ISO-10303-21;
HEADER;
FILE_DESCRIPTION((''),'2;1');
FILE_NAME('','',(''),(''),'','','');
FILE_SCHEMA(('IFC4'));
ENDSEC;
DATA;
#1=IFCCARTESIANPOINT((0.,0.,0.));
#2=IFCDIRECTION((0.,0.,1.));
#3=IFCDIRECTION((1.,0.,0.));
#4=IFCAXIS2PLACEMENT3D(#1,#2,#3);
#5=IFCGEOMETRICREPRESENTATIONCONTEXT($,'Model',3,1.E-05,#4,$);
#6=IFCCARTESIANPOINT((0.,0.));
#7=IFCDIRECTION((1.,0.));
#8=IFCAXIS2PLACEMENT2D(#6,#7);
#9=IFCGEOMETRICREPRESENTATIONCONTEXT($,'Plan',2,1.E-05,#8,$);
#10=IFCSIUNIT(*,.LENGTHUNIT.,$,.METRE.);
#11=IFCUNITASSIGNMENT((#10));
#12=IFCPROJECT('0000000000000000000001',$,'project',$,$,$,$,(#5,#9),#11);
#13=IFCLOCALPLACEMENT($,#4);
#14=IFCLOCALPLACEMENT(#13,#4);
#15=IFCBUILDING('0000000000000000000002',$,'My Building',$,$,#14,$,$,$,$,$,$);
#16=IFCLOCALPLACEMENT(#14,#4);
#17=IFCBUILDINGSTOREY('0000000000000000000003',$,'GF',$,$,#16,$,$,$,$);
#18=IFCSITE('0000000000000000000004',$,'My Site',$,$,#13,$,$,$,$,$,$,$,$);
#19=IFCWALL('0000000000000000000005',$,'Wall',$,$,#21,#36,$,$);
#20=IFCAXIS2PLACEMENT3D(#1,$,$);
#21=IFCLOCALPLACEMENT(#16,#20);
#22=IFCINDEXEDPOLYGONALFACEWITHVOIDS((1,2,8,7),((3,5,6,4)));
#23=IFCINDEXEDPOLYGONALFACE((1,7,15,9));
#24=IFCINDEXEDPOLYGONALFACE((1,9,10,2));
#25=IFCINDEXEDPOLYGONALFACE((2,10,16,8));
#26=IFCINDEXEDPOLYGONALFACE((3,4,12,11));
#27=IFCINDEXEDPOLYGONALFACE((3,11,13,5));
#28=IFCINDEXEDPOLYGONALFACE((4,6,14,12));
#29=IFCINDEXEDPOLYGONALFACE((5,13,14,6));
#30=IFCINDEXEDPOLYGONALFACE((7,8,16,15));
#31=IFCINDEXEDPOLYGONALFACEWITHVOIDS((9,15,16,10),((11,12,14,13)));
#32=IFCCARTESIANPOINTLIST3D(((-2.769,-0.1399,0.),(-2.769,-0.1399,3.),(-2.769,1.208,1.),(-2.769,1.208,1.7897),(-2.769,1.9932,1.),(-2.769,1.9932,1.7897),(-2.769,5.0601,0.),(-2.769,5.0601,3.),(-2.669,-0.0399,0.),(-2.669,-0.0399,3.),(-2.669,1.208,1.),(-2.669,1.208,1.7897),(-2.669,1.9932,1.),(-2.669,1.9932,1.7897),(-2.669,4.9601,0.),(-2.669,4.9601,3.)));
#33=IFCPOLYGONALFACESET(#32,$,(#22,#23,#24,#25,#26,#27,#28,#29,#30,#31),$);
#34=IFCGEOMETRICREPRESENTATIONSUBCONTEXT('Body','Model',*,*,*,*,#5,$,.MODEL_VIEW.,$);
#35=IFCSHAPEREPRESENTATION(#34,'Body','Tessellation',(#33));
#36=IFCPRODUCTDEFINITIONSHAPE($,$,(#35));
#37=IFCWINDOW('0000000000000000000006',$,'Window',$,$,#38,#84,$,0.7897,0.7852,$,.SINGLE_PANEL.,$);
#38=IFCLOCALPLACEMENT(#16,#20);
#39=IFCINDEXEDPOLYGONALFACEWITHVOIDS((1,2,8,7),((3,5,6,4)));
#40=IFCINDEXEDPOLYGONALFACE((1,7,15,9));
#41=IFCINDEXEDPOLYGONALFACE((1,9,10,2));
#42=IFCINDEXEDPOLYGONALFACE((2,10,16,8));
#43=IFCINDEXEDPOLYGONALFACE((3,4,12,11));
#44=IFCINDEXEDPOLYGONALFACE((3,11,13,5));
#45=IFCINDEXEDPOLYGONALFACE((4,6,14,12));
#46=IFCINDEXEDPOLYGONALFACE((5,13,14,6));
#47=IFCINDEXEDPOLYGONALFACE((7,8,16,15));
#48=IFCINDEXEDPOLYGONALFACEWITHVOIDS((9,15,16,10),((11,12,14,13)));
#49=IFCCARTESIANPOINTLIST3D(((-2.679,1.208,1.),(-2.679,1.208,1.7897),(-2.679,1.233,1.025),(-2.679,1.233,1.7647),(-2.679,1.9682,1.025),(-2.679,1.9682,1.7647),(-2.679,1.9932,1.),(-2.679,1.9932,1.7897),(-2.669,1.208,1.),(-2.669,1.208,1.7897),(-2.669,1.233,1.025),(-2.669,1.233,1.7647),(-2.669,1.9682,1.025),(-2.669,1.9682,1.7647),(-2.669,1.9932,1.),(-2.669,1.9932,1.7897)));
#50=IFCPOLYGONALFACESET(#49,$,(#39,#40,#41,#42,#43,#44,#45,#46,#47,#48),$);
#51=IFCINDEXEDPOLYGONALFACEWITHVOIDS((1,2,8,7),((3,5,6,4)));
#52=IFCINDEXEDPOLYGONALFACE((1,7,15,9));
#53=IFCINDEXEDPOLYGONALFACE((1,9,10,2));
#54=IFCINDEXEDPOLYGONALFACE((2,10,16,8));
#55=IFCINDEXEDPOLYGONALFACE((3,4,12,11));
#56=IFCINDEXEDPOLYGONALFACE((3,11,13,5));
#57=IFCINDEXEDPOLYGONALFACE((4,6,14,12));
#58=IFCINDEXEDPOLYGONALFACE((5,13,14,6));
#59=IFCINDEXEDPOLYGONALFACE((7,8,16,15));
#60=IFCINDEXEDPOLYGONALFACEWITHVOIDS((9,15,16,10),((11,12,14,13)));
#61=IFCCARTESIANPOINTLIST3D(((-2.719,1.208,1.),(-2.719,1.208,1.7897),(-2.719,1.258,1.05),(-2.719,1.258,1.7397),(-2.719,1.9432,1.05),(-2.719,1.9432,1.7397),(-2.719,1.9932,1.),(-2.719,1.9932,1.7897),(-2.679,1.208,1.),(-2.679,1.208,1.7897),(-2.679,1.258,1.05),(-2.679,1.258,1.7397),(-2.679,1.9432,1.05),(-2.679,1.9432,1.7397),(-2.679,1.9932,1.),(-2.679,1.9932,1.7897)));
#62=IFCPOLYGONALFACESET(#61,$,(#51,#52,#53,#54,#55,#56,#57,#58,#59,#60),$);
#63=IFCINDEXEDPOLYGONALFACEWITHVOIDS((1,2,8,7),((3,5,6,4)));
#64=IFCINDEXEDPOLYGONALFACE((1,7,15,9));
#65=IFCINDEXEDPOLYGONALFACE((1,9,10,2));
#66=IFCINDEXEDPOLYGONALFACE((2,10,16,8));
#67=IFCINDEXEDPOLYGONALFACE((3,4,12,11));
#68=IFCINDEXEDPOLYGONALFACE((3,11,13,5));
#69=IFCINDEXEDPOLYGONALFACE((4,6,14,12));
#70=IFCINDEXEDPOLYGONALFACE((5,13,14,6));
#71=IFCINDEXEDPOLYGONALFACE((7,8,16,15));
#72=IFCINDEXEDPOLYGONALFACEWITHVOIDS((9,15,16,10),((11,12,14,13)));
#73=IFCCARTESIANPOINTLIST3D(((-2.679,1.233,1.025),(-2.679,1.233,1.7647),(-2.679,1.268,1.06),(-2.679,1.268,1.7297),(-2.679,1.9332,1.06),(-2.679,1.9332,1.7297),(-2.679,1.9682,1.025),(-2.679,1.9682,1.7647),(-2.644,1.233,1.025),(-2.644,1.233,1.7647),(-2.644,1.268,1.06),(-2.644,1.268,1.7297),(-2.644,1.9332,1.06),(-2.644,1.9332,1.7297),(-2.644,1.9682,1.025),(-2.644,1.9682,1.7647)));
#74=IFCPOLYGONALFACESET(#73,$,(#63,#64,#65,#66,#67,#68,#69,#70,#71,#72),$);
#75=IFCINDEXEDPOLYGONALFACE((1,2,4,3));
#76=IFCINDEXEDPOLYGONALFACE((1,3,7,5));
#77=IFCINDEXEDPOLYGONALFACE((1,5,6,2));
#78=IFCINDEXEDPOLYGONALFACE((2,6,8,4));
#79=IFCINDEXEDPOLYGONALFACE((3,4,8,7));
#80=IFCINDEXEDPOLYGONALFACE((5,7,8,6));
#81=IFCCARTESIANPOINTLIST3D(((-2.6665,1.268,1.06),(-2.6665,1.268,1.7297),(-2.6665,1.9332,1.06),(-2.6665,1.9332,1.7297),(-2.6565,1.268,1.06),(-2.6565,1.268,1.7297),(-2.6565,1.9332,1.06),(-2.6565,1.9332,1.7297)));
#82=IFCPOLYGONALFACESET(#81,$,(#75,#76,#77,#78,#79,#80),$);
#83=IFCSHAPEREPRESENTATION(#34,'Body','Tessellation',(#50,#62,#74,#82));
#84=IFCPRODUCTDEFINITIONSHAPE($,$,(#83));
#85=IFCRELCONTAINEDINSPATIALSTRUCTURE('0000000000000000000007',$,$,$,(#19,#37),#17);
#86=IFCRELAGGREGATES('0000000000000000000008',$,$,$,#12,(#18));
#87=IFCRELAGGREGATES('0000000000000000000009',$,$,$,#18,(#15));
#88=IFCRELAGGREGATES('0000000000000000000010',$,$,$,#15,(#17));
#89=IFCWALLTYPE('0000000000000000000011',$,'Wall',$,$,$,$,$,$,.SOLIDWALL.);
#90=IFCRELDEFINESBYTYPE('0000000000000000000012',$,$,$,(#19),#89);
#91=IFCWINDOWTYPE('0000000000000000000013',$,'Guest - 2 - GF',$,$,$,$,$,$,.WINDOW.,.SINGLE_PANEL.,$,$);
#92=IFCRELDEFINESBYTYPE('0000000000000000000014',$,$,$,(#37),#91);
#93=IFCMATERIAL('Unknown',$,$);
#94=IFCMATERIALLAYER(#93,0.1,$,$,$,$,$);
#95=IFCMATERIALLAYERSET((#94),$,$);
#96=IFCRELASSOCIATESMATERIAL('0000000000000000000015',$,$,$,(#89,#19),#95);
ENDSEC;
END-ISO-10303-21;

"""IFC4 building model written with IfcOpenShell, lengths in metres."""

from ifc_helpers import new_model, entity, si_unit, frame, origin_with_axes, origin_2d_with_axis, place, context, subcontext, project, spatial, line, indexed_curve, outline, extrude, shape, source, transform, mapped, material, layer, layer_set, layer_usage, type_object, type_shapes, element, fill, save


model = new_model("IFC4")

# Units and contexts
model_context = context("Model", 3, precision=1e-05, world=origin_with_axes())
plan_context = context("Plan", 2, precision=1e-05, world=origin_2d_with_axis())
body_context_1 = subcontext(model_context, "Body", "Model", "MODEL_VIEW")
body_context_2 = subcontext(plan_context, "Body", "Plan", "PLAN_VIEW")
ifc_project = project(units=[si_unit("LENGTHUNIT", "METRE")], contexts=[model_context, plan_context])

# Site, building, storey
site_placement = place(None, origin_with_axes())
site = spatial("IfcSite", under=ifc_project, at=site_placement, Name="My Site")
building_placement = place(site_placement, origin_with_axes())
building = spatial("IfcBuilding", under=site, at=building_placement, Name="My Building")
storey_placement = place(building_placement, origin_with_axes())
storey = spatial("IfcBuildingStorey", under=building, at=storey_placement, Name="GF")

# Shared definitions
ifc_material = material(Name="Unknown")

# Shared definitions
ifc_layer_1 = layer(ifc_material, 0.1)
ifc_layer_set_1 = layer_set([ifc_layer_1])
wall_type = type_object("IfcWallType", Name="Wall", PredefinedType="SOLIDWALL", material=ifc_layer_set_1)

# Wall, opening, window
ifc_layer_usage_1 = layer_usage(ifc_layer_set_1, "AXIS2", "POSITIVE", 0.0)
wall_1_placement = place(storey_placement, frame((-2.769, 5.0601, 0.0), z_axis=(0.0, 0.0, 1.0), x_axis=(0.0, -1.0, 0.0)))
wall_1 = element("IfcWall", 1, at=wall_1_placement, inside=storey, type_object=wall_type, material=ifc_layer_usage_1, Name="Wall", context=body_context_1, shape_type="SweptSolid", body=[
    extrude(outline(indexed_curve([(0.0, 0.0), (0.1, 0.1), (5.1, 0.1), (5.2, 0.0)], segments=[line(1, 2, 3, 4, 1)])), origin_with_axes(), (0.0, 0.0, 1.0), 3.0),
])
shared_shape_1 = source(origin_with_axes(), body_context_1, "Body", "SweptSolid", [
    extrude(outline(indexed_curve([(0.0, 0.0), (0.7852, 0.0), (0.7852, 0.7897), (0.0, 0.7897)], segments=[line(1, 2, 3, 4, 1)])), frame((0.0, -0.6, 0.0), z_axis=(0.0, -1.0, 0.0), x_axis=(1.0, 0.0, 0.0)), (0.0, 0.0, -1.0), 1.2),
])
opening_1_placement = place(wall_1_placement, frame((3.0669, 0.0, 1.0), z_axis=(0.0, 0.0, 1.0), x_axis=(1.0, 0.0, 0.0)))
opening_1 = element("IfcOpeningElement", 2, at=opening_1_placement, cuts=wall_1, PredefinedType="OPENING", context=body_context_1, shape_type="MappedRepresentation", body=[
    mapped(shared_shape_1, transform((0.0, 0.0, 0.0), x_axis=(1.0, 0.0, 0.0), y_axis=(0.0, 1.0, 0.0), z_axis=(0.0, 0.0, 1.0), scale=1.0)),
])
window_type_1 = type_object("IfcWindowType", Name="Guest - 2 - GF", PartitioningType="SINGLE_PANEL", PredefinedType="WINDOW")
shared_shape_2 = source(origin_with_axes(), body_context_1, "Body", "SweptSolid", [
    extrude(outline(indexed_curve([(0.0, 0.0), (0.7852, 0.0), (0.7852, 0.7897), (0.0, 0.7897)], segments=[line(1, 2, 3, 4, 1)]), holes=[indexed_curve([(0.025, 0.025), (0.7602, 0.025), (0.7602, 0.7647), (0.025, 0.7647)], segments=[line(1, 2, 3, 4, 1)])]), frame((0.0, 0.09, 0.0), z_axis=(0.0, -1.0, 0.0), x_axis=(1.0, 0.0, 0.0)), (0.0, 0.0, -1.0), 0.01),
    extrude(outline(indexed_curve([(0.0, 0.0), (0.7852, 0.0), (0.7852, 0.7897), (0.0, 0.7897)], segments=[line(1, 2, 3, 4, 1)]), holes=[indexed_curve([(0.05, 0.05), (0.7352, 0.05), (0.7352, 0.7397), (0.05, 0.7397)], segments=[line(1, 2, 3, 4, 1)])]), frame((0.0, 0.05, 0.0), z_axis=(0.0, -1.0, 0.0), x_axis=(1.0, 0.0, 0.0)), (0.0, 0.0, -1.0), 0.04),
    extrude(outline(indexed_curve([(0.0, 0.0), (0.7352, 0.0), (0.7352, 0.7397), (0.0, 0.7397)], segments=[line(1, 2, 3, 4, 1)]), holes=[indexed_curve([(0.035, 0.035), (0.7002, 0.035), (0.7002, 0.7047), (0.035, 0.7047)], segments=[line(1, 2, 3, 4, 1)])]), frame((0.025, 0.09, 0.025), z_axis=(0.0, -1.0, 0.0), x_axis=(1.0, 0.0, 0.0)), (0.0, 0.0, -1.0), 0.035),
    extrude(outline(indexed_curve([(0.035, 0.035), (0.7002, 0.035), (0.7002, 0.7047), (0.035, 0.7047)], segments=[line(1, 2, 3, 4, 1)])), frame((0.025, 0.1025, 0.025), z_axis=(0.0, -1.0, 0.0), x_axis=(1.0, 0.0, 0.0)), (0.0, 0.0, -1.0), 0.01),
])
shared_shape_3 = source(origin_with_axes(), body_context_2, "Body", "Curve2D", [
    entity("IfcIndexedPolyCurve", entity("IfcCartesianPointList2D", [[0.05, 0.05], [0.7352, 0.05]])),
    entity("IfcIndexedPolyCurve", entity("IfcCartesianPointList2D", [[0.0, 0.1], [0.025, 0.1], [0.025, 0.09], [0.05, 0.09], [0.05, 0.05], [0.0, 0.05]]), [entity("IfcLineIndex", [1, 2, 3, 4, 5, 6, 1])]),
    entity("IfcIndexedPolyCurve", entity("IfcCartesianPointList2D", [[0.7852, 0.1], [0.7602, 0.1], [0.7602, 0.09], [0.7352, 0.09], [0.7352, 0.05], [0.7852, 0.05]]), [entity("IfcLineIndex", [1, 2, 3, 4, 5, 6, 1])]),
    entity("IfcIndexedPolyCurve", entity("IfcCartesianPointList2D", [[0.025, 0.09], [0.06, 0.09], [0.06, 0.125], [0.025, 0.125]]), [entity("IfcLineIndex", [1, 2, 3, 4, 1])]),
    entity("IfcIndexedPolyCurve", entity("IfcCartesianPointList2D", [[0.7602, 0.09], [0.7252, 0.09], [0.7252, 0.125], [0.7602, 0.125]]), [entity("IfcLineIndex", [1, 2, 3, 4, 1])]),
    entity("IfcIndexedPolyCurve", entity("IfcCartesianPointList2D", [[0.06, 0.09], [0.7252, 0.09]])),
    entity("IfcIndexedPolyCurve", entity("IfcCartesianPointList2D", [[0.06, 0.125], [0.7252, 0.125]])),
    entity("IfcIndexedPolyCurve", entity("IfcCartesianPointList2D", [[0.06, 0.1075], [0.7252, 0.1075]])),
])
type_shapes(window_type_1, [shared_shape_2, shared_shape_3])
window_1_placement = place(opening_1_placement, frame((0.0, 0.0, 0.0), z_axis=(0.0, 0.0, 1.0), x_axis=(1.0, 0.0, 0.0)))
window_1 = element("IfcWindow", 3, at=window_1_placement, inside=storey, type_object=window_type_1, Name="Window", OverallHeight=0.7897, OverallWidth=0.7852, PartitioningType="SINGLE_PANEL", shapes=[
    shape(body_context_1, "Body", "MappedRepresentation", [mapped(shared_shape_2, transform((0.0, 0.0, 0.0), x_axis=(1.0, 0.0, 0.0), y_axis=(0.0, 1.0, 0.0), z_axis=(0.0, 0.0, 1.0), scale=1.0))]),
    shape(body_context_2, "Body", "MappedRepresentation", [mapped(shared_shape_3, transform((0.0, 0.0, 0.0), x_axis=(1.0, 0.0, 0.0), y_axis=(0.0, 1.0, 0.0), z_axis=(0.0, 0.0, 1.0), scale=1.0))]),
])
fill(opening_1, window_1)

save(model, "model.ifc")
